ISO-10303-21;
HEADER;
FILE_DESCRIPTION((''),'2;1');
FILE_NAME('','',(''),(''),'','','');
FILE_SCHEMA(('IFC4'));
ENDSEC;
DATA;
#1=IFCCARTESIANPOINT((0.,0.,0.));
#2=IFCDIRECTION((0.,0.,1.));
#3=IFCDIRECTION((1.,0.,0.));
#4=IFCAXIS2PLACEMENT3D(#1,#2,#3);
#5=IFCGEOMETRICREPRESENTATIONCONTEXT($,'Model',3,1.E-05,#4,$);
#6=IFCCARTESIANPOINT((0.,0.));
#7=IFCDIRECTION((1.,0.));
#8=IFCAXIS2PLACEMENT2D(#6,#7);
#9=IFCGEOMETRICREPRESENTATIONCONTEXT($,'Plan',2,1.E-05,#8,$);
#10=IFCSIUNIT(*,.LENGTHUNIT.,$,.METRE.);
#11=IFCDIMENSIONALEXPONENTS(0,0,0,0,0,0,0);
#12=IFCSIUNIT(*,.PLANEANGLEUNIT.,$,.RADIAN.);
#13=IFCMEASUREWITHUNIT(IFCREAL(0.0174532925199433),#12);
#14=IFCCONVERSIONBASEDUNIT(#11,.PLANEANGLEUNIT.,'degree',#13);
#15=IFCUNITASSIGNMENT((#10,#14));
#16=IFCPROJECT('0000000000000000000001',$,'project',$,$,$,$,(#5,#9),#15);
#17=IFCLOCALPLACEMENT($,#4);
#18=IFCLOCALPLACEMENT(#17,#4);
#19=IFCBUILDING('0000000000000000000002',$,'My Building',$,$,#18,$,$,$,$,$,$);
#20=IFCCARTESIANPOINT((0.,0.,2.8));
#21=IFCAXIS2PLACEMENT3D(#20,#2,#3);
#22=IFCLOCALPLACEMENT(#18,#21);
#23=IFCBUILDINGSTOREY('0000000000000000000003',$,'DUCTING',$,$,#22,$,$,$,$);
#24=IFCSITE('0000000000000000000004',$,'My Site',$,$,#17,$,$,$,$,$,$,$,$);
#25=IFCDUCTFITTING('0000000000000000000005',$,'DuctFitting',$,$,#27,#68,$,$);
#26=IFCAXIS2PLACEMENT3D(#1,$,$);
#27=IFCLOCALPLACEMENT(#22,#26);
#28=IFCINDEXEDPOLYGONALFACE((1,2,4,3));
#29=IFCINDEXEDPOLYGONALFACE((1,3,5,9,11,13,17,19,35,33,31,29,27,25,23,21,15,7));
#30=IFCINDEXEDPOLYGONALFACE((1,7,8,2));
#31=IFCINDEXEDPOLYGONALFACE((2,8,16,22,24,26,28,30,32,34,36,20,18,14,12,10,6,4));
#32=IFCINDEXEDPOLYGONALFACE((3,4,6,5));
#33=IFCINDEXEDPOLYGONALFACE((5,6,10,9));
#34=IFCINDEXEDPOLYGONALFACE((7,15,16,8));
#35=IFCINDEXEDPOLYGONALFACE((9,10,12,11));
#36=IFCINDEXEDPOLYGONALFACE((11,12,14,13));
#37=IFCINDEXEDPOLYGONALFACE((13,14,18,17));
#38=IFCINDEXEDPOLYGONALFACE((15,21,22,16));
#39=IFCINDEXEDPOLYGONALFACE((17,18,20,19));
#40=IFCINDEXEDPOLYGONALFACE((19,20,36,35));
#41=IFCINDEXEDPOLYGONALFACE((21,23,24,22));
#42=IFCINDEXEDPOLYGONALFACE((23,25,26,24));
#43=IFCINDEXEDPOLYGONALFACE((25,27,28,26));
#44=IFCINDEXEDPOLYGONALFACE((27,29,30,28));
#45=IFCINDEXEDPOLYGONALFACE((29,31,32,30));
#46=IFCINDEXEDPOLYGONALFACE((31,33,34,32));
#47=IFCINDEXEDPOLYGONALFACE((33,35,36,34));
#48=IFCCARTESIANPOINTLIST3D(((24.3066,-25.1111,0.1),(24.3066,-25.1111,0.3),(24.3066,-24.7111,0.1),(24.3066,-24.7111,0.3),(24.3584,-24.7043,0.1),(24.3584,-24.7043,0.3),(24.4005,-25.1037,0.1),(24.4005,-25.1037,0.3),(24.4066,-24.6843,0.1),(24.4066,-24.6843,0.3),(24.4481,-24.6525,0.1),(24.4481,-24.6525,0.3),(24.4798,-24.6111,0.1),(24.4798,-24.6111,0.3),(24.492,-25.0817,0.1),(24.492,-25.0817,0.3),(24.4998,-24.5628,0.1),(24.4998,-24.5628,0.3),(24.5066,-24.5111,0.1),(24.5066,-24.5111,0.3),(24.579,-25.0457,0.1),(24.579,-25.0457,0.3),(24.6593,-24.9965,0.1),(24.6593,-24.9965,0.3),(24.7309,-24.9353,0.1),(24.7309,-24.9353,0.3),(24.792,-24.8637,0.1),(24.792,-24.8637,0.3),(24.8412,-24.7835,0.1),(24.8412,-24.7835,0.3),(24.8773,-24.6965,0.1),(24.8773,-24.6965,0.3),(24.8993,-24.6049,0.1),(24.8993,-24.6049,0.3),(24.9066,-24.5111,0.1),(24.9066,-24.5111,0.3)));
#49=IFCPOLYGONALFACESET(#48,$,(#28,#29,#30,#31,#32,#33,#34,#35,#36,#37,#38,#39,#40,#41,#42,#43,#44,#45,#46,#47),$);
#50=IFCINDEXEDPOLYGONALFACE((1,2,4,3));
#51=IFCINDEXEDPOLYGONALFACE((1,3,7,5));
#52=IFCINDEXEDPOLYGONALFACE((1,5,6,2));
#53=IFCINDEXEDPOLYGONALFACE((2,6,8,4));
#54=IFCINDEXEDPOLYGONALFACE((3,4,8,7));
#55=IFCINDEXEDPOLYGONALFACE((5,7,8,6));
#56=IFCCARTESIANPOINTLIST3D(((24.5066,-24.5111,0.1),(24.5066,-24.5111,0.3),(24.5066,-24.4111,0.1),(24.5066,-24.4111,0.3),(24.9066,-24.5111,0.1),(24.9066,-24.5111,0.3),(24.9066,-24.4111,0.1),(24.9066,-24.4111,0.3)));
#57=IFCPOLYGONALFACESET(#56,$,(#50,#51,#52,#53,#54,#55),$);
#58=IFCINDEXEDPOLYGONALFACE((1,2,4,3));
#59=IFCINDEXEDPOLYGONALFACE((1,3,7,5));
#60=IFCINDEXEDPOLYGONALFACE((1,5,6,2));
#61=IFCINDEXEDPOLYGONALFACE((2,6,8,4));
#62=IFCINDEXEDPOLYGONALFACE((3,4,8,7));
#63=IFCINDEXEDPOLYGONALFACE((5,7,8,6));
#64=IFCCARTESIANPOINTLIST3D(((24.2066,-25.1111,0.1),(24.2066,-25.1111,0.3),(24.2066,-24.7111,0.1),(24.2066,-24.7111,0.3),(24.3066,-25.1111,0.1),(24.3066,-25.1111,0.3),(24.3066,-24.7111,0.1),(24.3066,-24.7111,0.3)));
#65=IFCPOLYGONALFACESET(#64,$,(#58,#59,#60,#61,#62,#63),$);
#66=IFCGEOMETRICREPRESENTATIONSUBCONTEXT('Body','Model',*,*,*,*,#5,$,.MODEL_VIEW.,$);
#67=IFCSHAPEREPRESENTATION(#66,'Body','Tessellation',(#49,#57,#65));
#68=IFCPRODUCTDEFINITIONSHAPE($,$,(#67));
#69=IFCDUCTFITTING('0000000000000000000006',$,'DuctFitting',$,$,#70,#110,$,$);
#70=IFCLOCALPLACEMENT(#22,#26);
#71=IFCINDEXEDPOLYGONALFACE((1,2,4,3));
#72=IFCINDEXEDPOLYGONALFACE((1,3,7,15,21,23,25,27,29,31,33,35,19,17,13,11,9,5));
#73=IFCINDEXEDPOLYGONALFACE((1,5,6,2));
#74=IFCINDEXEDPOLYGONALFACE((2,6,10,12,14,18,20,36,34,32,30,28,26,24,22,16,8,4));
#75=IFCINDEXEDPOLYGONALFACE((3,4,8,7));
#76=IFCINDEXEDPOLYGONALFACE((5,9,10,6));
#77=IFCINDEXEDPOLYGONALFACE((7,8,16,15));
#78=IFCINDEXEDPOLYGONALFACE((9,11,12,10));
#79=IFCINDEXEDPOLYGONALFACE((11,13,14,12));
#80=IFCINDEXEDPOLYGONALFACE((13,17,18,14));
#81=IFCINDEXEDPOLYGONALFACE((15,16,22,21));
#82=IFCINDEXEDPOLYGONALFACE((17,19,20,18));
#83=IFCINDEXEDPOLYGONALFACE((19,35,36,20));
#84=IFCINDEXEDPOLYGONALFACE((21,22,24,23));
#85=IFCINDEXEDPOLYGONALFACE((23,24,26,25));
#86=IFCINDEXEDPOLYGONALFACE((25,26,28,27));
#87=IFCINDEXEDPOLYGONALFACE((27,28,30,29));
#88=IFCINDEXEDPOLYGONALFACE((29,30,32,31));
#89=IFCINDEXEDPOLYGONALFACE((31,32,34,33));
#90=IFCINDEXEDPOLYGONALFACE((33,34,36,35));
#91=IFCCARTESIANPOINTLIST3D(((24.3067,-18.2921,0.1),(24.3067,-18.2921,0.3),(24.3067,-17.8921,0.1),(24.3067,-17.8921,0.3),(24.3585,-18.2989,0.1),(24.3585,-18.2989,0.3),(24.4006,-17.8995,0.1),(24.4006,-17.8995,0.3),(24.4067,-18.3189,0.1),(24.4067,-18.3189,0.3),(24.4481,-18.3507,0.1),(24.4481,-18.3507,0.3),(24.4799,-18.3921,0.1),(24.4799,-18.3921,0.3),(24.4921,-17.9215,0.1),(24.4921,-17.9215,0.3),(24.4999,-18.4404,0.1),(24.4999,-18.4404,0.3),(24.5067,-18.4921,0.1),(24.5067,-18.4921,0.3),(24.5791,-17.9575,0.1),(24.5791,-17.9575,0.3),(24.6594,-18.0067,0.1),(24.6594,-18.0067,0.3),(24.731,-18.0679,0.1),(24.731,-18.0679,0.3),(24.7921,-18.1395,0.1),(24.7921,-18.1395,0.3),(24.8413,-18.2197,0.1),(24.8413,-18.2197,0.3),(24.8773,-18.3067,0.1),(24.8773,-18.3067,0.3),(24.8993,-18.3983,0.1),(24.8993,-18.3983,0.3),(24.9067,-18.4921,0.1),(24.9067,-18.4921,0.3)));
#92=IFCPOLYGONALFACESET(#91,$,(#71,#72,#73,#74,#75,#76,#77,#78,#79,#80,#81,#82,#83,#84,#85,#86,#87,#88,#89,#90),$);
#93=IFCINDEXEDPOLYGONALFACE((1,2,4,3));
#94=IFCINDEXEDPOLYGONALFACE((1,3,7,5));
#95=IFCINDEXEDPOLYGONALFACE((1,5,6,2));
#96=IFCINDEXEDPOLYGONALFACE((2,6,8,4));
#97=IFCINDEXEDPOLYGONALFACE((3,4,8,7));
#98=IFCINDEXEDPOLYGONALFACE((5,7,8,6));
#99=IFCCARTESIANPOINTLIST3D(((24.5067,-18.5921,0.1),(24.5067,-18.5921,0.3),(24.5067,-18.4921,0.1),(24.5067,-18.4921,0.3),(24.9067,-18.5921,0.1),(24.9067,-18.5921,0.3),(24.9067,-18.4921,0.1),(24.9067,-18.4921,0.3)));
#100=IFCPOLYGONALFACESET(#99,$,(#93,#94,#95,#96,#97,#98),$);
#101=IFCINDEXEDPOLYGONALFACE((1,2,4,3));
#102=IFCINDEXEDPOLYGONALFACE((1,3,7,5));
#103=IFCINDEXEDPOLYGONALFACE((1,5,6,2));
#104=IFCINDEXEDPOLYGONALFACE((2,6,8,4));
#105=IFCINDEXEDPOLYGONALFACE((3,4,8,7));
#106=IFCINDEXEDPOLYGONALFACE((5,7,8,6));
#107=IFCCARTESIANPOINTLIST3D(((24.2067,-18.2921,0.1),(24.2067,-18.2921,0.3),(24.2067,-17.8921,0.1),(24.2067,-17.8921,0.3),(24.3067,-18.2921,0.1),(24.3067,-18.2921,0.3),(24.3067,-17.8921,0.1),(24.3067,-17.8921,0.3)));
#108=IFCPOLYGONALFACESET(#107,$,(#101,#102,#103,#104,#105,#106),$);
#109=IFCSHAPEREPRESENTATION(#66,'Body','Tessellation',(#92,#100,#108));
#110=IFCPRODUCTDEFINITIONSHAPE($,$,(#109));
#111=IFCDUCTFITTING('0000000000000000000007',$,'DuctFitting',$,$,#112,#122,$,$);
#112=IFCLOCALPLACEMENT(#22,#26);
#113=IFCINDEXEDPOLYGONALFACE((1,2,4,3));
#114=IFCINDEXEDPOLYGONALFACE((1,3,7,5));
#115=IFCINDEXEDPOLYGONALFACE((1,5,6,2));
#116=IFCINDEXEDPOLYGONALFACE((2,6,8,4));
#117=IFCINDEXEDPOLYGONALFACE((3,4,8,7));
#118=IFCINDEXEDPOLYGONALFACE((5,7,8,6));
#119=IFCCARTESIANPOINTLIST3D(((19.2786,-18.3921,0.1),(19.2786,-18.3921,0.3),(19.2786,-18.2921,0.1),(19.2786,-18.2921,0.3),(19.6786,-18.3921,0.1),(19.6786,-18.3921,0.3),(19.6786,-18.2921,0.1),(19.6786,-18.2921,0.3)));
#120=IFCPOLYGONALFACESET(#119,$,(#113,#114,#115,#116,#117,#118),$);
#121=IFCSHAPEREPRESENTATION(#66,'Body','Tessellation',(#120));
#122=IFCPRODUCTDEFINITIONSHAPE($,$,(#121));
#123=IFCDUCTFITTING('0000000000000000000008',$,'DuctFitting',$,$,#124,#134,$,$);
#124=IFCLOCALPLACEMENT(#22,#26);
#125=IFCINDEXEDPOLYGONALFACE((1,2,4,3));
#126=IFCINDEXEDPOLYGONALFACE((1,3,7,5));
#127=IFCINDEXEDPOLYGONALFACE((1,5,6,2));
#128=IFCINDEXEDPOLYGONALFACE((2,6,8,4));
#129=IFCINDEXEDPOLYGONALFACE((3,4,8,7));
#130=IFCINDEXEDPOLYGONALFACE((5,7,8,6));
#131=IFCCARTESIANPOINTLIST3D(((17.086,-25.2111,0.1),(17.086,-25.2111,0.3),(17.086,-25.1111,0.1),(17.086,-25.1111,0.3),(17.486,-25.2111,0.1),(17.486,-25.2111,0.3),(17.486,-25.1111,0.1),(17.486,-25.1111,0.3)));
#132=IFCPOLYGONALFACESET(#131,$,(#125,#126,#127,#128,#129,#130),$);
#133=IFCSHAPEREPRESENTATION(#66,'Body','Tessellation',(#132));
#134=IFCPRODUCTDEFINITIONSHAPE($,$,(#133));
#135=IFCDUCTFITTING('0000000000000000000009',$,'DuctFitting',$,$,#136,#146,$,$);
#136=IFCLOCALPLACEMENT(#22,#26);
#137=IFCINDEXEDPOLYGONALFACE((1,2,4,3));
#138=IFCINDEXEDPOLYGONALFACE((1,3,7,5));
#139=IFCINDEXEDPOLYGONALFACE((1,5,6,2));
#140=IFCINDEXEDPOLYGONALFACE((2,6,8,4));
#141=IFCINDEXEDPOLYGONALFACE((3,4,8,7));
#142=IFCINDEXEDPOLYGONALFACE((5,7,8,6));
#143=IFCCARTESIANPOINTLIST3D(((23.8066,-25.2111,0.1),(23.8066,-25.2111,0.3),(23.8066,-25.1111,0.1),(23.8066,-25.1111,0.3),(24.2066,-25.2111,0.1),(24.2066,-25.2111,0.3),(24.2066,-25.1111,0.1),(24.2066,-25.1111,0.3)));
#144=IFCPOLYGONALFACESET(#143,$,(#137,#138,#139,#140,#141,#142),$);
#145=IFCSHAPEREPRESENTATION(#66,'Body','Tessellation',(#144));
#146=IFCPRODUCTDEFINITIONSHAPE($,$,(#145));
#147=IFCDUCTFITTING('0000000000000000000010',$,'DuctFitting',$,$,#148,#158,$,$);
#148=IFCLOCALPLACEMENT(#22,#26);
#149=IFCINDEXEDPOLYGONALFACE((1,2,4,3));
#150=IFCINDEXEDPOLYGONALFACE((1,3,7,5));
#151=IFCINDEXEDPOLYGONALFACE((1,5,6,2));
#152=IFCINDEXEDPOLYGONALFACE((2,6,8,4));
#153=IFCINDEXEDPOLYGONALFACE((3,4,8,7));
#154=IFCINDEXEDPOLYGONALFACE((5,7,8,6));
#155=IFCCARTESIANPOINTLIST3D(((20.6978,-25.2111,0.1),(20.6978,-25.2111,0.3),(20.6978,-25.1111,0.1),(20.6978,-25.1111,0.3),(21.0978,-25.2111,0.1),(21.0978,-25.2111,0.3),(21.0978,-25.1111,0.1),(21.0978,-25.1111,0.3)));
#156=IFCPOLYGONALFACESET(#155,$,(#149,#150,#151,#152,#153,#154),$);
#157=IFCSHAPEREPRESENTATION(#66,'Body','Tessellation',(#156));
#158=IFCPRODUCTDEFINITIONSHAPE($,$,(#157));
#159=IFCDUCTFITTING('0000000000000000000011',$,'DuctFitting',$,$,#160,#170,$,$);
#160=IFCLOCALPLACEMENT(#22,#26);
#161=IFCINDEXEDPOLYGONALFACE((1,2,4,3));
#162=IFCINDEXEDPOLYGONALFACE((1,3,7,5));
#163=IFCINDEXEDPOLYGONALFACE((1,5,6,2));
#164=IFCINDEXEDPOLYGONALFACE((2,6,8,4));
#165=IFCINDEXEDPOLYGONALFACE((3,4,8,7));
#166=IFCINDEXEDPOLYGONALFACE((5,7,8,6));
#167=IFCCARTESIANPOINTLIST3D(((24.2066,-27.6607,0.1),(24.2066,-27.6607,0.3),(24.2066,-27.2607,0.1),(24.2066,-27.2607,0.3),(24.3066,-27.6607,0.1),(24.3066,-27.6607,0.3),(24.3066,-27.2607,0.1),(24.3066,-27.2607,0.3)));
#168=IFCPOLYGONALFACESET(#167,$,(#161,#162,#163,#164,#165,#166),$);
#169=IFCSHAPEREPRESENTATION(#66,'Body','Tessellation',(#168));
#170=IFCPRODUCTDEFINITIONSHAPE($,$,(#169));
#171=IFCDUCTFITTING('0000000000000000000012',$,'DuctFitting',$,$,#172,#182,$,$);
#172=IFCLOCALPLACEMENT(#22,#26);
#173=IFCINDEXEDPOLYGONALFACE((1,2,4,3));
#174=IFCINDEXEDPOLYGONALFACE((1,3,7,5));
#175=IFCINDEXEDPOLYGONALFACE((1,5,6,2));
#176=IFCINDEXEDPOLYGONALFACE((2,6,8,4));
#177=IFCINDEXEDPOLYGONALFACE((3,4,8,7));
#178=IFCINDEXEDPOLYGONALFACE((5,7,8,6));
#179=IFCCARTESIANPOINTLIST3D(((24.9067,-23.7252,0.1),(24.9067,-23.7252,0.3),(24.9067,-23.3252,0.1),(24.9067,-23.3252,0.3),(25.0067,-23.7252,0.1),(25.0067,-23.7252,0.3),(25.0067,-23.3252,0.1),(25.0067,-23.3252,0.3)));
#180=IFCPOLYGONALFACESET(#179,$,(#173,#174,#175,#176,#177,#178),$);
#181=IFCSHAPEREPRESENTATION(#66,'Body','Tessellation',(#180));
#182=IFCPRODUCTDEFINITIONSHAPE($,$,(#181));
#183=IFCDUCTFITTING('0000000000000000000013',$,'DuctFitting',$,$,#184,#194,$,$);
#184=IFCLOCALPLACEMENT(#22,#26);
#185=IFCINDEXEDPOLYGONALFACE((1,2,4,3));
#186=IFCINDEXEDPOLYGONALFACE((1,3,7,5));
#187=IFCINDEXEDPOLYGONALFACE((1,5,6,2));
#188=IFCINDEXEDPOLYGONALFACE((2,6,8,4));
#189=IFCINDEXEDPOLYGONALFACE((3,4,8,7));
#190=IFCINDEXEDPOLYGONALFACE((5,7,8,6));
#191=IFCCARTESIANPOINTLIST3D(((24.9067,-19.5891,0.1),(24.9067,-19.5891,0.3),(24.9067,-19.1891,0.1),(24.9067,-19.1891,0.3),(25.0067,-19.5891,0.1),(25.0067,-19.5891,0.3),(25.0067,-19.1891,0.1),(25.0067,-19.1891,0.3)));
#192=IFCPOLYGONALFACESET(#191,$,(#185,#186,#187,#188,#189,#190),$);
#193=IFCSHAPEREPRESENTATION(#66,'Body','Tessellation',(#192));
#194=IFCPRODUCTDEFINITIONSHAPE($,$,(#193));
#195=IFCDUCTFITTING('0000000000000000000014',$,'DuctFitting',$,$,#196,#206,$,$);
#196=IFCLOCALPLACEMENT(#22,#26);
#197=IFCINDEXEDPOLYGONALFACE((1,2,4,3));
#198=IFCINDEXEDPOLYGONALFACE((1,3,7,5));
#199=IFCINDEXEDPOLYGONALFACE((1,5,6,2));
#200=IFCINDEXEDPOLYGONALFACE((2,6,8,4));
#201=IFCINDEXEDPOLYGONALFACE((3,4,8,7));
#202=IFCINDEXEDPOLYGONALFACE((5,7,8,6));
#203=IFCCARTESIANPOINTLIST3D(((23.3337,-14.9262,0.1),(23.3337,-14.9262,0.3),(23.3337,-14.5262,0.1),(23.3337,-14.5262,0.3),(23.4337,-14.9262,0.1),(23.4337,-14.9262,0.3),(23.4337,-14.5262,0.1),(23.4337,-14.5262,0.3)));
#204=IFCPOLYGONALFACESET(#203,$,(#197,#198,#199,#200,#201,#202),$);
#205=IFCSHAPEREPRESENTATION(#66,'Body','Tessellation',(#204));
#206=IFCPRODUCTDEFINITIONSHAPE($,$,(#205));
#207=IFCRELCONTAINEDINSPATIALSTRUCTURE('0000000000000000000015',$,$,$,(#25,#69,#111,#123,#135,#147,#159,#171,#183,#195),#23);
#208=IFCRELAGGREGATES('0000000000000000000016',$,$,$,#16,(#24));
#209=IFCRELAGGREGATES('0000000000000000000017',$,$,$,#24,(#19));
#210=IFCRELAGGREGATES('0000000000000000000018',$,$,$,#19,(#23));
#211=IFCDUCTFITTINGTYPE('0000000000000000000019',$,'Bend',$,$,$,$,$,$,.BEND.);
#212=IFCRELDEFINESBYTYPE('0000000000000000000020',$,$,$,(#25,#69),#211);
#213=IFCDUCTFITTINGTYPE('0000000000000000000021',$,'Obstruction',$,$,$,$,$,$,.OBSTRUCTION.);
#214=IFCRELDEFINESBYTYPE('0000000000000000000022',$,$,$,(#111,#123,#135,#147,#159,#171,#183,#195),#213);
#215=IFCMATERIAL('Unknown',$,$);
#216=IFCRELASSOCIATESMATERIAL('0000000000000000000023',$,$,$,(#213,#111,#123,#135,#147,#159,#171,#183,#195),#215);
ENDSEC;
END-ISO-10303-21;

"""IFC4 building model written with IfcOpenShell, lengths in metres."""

from ifc_helpers import new_model, entity, si_unit, converted_unit, frame, origin_with_axes, origin_2d_with_axis, place, context, subcontext, project, spatial, line, arc, indexed_curve, rectangle, outline, extrude, source, transform, mapped, material, material_profile, profile_set, profile_usage, type_object, type_shapes, element, save


model = new_model("IFC4")

# Units and contexts
model_context = context("Model", 3, precision=1e-05, world=origin_with_axes())
plan_context = context("Plan", 2, precision=1e-05, world=origin_2d_with_axis())
body_context = subcontext(model_context, "Body", "Model", "MODEL_VIEW")
ifc_project = project(units=[si_unit("LENGTHUNIT", "METRE"), converted_unit("PLANEANGLEUNIT", "degree", entity("IfcReal", 0.0174532925199433), si_unit("PLANEANGLEUNIT", "RADIAN"), dimensions=[0, 0, 0, 0, 0, 0, 0])], contexts=[model_context, plan_context])

# Site, building, storey
site_placement = place(None, origin_with_axes())
site = spatial("IfcSite", under=ifc_project, at=site_placement, Name="My Site")
building_placement = place(site_placement, origin_with_axes())
building = spatial("IfcBuilding", under=site, at=building_placement, Name="My Building")
storey_placement = place(building_placement, frame((0.0, 0.0, 2.8), z_axis=(0.0, 0.0, 1.0), x_axis=(1.0, 0.0, 0.0)))
storey = spatial("IfcBuildingStorey", under=building, at=storey_placement, Name="DUCTING")

# Shared definitions
ifc_material = material(Name="Unknown")

# Duct fittings
duct_fitting_type_1 = type_object("IfcDuctFittingType", Name="Bend", PredefinedType="BEND")
shared_shape = source(origin_with_axes(), body_context, "Body", "SweptSolid", [
    extrude(outline(indexed_curve([(-0.2, 0.0), (-0.2586, -0.1414), (-0.4, -0.2), (-0.4, -0.6), (0.0243, -0.4243), (0.2, 0.0)], segments=[arc(1, 2, 3), line(3, 4), arc(4, 5, 6), line(6, 1)])), frame((0.0, -0.1, -0.1), z_axis=(0.0, -1.0, 0.0), x_axis=(1.0, 0.0, 0.0)), (0.0, 0.0, -1.0), 0.2),
    extrude(rectangle(XDim=0.4, YDim=0.2), origin_with_axes(), (0.0, 0.0, -1.0), 0.1),
    extrude(rectangle(XDim=0.4, YDim=0.2), frame((-0.4, 0.0, -0.5), z_axis=(-1.0, 0.0, 0.0), x_axis=(0.0, 0.0, -1.0)), (0.0, 0.0, 1.0), 0.1),
])
type_shapes(duct_fitting_type_1, [shared_shape])
for number, where, z_axis, x_axis, name in (
    (1, (24.7066, -24.4111, 0.2), (0.00001, 1.0, -0.000001), (1.0, -0.00001, 0.0), "DuctFitting"),
    (2, (24.7067, -18.5921, 0.2), (-0.00001, -1.0, 0.000001), (1.0, -0.00001, 0.0), "DuctFitting"),
):
    element("IfcDuctFitting", number, at=place(storey_placement, frame(where, z_axis=z_axis, x_axis=x_axis)), inside=storey, type_object=duct_fitting_type_1, Name=name, context=body_context, shape_type="MappedRepresentation", body=[
        mapped(shared_shape, transform((0.0, 0.0, 0.0), x_axis=(1.0, 0.0, 0.0), y_axis=(0.0, 1.0, 0.0), z_axis=(0.0, 0.0, 1.0), scale=1.0)),
    ])
ifc_material_profile_1 = material_profile(ifc_material, rectangle(XDim=0.4, YDim=0.2))
ifc_profile_set_1 = profile_set([ifc_material_profile_1])
ifc_profile_usage_1 = profile_usage(ifc_profile_set_1, cardinal=5)
duct_fitting_type_2 = type_object("IfcDuctFittingType", Name="Obstruction", PredefinedType="OBSTRUCTION", material=ifc_profile_set_1)
duct_fitting_1_placement = place(storey_placement, frame((19.4786, -18.2921, 0.2), z_axis=(0.0, -1.0, 0.0), x_axis=(1.0, 0.0, 0.0)))
element("IfcDuctFitting", 3, at=duct_fitting_1_placement, inside=storey, type_object=duct_fitting_type_2, material=ifc_profile_usage_1, Name="DuctFitting", context=body_context, shape_type="SweptSolid", body=[
    extrude(rectangle(XDim=0.4, YDim=0.2), origin_with_axes(), (0.0, 0.0, 1.0), 0.1),
])
ifc_profile_usage_2 = profile_usage(ifc_profile_set_1, cardinal=5)
duct_fitting_2_placement = place(storey_placement, frame((17.286, -25.1111, 0.2), z_axis=(0.0, -1.0, 0.0), x_axis=(1.0, 0.0, 0.0)))
element("IfcDuctFitting", 4, at=duct_fitting_2_placement, inside=storey, type_object=duct_fitting_type_2, material=ifc_profile_usage_2, Name="DuctFitting", context=body_context, shape_type="SweptSolid", body=[
    extrude(rectangle(XDim=0.4, YDim=0.2), origin_with_axes(), (0.0, 0.0, 1.0), 0.1),
])
ifc_profile_usage_3 = profile_usage(ifc_profile_set_1, cardinal=5)
duct_fitting_3_placement = place(storey_placement, frame((24.0066, -25.1111, 0.2), z_axis=(0.0, -1.0, 0.0), x_axis=(1.0, 0.0, 0.0)))
element("IfcDuctFitting", 5, at=duct_fitting_3_placement, inside=storey, type_object=duct_fitting_type_2, material=ifc_profile_usage_3, Name="DuctFitting", context=body_context, shape_type="SweptSolid", body=[
    extrude(rectangle(XDim=0.4, YDim=0.2), origin_with_axes(), (0.0, 0.0, 1.0), 0.1),
])
ifc_profile_usage_4 = profile_usage(ifc_profile_set_1, cardinal=5)
duct_fitting_4_placement = place(storey_placement, frame((20.8978, -25.1111, 0.2), z_axis=(0.0, -1.0, 0.0), x_axis=(1.0, 0.0, 0.0)))
element("IfcDuctFitting", 6, at=duct_fitting_4_placement, inside=storey, type_object=duct_fitting_type_2, material=ifc_profile_usage_4, Name="DuctFitting", context=body_context, shape_type="SweptSolid", body=[
    extrude(rectangle(XDim=0.4, YDim=0.2), origin_with_axes(), (0.0, 0.0, 1.0), 0.1),
])
ifc_profile_usage_5 = profile_usage(ifc_profile_set_1, cardinal=5)
duct_fitting_5_placement = place(storey_placement, frame((24.2066, -27.4607, 0.2), z_axis=(1.0, 0.0, 0.0), x_axis=(0.0, 1.0, 0.0)))
element("IfcDuctFitting", 7, at=duct_fitting_5_placement, inside=storey, type_object=duct_fitting_type_2, material=ifc_profile_usage_5, Name="DuctFitting", context=body_context, shape_type="SweptSolid", body=[
    extrude(rectangle(XDim=0.4, YDim=0.2), origin_with_axes(), (0.0, 0.0, 1.0), 0.1),
])
ifc_profile_usage_6 = profile_usage(ifc_profile_set_1, cardinal=5)
duct_fitting_6_placement = place(storey_placement, frame((24.9067, -23.5252, 0.2), z_axis=(1.0, 0.0, 0.0), x_axis=(0.0, 1.0, 0.0)))
element("IfcDuctFitting", 8, at=duct_fitting_6_placement, inside=storey, type_object=duct_fitting_type_2, material=ifc_profile_usage_6, Name="DuctFitting", context=body_context, shape_type="SweptSolid", body=[
    extrude(rectangle(XDim=0.4, YDim=0.2), origin_with_axes(), (0.0, 0.0, 1.0), 0.1),
])
ifc_profile_usage_7 = profile_usage(ifc_profile_set_1, cardinal=5)
duct_fitting_7_placement = place(storey_placement, frame((24.9067, -19.3891, 0.2), z_axis=(1.0, 0.0, 0.0), x_axis=(0.0, 1.0, 0.0)))
element("IfcDuctFitting", 9, at=duct_fitting_7_placement, inside=storey, type_object=duct_fitting_type_2, material=ifc_profile_usage_7, Name="DuctFitting", context=body_context, shape_type="SweptSolid", body=[
    extrude(rectangle(XDim=0.4, YDim=0.2), origin_with_axes(), (0.0, 0.0, 1.0), 0.1),
])
ifc_profile_usage_8 = profile_usage(ifc_profile_set_1, cardinal=5)
duct_fitting_8_placement = place(storey_placement, frame((23.3337, -14.7262, 0.2), z_axis=(1.0, 0.0, 0.0), x_axis=(0.0, 1.0, 0.0)))
element("IfcDuctFitting", 10, at=duct_fitting_8_placement, inside=storey, type_object=duct_fitting_type_2, material=ifc_profile_usage_8, Name="DuctFitting", context=body_context, shape_type="SweptSolid", body=[
    extrude(rectangle(XDim=0.4, YDim=0.2), origin_with_axes(), (0.0, 0.0, 1.0), 0.1),
])

save(model, "model.ifc")
